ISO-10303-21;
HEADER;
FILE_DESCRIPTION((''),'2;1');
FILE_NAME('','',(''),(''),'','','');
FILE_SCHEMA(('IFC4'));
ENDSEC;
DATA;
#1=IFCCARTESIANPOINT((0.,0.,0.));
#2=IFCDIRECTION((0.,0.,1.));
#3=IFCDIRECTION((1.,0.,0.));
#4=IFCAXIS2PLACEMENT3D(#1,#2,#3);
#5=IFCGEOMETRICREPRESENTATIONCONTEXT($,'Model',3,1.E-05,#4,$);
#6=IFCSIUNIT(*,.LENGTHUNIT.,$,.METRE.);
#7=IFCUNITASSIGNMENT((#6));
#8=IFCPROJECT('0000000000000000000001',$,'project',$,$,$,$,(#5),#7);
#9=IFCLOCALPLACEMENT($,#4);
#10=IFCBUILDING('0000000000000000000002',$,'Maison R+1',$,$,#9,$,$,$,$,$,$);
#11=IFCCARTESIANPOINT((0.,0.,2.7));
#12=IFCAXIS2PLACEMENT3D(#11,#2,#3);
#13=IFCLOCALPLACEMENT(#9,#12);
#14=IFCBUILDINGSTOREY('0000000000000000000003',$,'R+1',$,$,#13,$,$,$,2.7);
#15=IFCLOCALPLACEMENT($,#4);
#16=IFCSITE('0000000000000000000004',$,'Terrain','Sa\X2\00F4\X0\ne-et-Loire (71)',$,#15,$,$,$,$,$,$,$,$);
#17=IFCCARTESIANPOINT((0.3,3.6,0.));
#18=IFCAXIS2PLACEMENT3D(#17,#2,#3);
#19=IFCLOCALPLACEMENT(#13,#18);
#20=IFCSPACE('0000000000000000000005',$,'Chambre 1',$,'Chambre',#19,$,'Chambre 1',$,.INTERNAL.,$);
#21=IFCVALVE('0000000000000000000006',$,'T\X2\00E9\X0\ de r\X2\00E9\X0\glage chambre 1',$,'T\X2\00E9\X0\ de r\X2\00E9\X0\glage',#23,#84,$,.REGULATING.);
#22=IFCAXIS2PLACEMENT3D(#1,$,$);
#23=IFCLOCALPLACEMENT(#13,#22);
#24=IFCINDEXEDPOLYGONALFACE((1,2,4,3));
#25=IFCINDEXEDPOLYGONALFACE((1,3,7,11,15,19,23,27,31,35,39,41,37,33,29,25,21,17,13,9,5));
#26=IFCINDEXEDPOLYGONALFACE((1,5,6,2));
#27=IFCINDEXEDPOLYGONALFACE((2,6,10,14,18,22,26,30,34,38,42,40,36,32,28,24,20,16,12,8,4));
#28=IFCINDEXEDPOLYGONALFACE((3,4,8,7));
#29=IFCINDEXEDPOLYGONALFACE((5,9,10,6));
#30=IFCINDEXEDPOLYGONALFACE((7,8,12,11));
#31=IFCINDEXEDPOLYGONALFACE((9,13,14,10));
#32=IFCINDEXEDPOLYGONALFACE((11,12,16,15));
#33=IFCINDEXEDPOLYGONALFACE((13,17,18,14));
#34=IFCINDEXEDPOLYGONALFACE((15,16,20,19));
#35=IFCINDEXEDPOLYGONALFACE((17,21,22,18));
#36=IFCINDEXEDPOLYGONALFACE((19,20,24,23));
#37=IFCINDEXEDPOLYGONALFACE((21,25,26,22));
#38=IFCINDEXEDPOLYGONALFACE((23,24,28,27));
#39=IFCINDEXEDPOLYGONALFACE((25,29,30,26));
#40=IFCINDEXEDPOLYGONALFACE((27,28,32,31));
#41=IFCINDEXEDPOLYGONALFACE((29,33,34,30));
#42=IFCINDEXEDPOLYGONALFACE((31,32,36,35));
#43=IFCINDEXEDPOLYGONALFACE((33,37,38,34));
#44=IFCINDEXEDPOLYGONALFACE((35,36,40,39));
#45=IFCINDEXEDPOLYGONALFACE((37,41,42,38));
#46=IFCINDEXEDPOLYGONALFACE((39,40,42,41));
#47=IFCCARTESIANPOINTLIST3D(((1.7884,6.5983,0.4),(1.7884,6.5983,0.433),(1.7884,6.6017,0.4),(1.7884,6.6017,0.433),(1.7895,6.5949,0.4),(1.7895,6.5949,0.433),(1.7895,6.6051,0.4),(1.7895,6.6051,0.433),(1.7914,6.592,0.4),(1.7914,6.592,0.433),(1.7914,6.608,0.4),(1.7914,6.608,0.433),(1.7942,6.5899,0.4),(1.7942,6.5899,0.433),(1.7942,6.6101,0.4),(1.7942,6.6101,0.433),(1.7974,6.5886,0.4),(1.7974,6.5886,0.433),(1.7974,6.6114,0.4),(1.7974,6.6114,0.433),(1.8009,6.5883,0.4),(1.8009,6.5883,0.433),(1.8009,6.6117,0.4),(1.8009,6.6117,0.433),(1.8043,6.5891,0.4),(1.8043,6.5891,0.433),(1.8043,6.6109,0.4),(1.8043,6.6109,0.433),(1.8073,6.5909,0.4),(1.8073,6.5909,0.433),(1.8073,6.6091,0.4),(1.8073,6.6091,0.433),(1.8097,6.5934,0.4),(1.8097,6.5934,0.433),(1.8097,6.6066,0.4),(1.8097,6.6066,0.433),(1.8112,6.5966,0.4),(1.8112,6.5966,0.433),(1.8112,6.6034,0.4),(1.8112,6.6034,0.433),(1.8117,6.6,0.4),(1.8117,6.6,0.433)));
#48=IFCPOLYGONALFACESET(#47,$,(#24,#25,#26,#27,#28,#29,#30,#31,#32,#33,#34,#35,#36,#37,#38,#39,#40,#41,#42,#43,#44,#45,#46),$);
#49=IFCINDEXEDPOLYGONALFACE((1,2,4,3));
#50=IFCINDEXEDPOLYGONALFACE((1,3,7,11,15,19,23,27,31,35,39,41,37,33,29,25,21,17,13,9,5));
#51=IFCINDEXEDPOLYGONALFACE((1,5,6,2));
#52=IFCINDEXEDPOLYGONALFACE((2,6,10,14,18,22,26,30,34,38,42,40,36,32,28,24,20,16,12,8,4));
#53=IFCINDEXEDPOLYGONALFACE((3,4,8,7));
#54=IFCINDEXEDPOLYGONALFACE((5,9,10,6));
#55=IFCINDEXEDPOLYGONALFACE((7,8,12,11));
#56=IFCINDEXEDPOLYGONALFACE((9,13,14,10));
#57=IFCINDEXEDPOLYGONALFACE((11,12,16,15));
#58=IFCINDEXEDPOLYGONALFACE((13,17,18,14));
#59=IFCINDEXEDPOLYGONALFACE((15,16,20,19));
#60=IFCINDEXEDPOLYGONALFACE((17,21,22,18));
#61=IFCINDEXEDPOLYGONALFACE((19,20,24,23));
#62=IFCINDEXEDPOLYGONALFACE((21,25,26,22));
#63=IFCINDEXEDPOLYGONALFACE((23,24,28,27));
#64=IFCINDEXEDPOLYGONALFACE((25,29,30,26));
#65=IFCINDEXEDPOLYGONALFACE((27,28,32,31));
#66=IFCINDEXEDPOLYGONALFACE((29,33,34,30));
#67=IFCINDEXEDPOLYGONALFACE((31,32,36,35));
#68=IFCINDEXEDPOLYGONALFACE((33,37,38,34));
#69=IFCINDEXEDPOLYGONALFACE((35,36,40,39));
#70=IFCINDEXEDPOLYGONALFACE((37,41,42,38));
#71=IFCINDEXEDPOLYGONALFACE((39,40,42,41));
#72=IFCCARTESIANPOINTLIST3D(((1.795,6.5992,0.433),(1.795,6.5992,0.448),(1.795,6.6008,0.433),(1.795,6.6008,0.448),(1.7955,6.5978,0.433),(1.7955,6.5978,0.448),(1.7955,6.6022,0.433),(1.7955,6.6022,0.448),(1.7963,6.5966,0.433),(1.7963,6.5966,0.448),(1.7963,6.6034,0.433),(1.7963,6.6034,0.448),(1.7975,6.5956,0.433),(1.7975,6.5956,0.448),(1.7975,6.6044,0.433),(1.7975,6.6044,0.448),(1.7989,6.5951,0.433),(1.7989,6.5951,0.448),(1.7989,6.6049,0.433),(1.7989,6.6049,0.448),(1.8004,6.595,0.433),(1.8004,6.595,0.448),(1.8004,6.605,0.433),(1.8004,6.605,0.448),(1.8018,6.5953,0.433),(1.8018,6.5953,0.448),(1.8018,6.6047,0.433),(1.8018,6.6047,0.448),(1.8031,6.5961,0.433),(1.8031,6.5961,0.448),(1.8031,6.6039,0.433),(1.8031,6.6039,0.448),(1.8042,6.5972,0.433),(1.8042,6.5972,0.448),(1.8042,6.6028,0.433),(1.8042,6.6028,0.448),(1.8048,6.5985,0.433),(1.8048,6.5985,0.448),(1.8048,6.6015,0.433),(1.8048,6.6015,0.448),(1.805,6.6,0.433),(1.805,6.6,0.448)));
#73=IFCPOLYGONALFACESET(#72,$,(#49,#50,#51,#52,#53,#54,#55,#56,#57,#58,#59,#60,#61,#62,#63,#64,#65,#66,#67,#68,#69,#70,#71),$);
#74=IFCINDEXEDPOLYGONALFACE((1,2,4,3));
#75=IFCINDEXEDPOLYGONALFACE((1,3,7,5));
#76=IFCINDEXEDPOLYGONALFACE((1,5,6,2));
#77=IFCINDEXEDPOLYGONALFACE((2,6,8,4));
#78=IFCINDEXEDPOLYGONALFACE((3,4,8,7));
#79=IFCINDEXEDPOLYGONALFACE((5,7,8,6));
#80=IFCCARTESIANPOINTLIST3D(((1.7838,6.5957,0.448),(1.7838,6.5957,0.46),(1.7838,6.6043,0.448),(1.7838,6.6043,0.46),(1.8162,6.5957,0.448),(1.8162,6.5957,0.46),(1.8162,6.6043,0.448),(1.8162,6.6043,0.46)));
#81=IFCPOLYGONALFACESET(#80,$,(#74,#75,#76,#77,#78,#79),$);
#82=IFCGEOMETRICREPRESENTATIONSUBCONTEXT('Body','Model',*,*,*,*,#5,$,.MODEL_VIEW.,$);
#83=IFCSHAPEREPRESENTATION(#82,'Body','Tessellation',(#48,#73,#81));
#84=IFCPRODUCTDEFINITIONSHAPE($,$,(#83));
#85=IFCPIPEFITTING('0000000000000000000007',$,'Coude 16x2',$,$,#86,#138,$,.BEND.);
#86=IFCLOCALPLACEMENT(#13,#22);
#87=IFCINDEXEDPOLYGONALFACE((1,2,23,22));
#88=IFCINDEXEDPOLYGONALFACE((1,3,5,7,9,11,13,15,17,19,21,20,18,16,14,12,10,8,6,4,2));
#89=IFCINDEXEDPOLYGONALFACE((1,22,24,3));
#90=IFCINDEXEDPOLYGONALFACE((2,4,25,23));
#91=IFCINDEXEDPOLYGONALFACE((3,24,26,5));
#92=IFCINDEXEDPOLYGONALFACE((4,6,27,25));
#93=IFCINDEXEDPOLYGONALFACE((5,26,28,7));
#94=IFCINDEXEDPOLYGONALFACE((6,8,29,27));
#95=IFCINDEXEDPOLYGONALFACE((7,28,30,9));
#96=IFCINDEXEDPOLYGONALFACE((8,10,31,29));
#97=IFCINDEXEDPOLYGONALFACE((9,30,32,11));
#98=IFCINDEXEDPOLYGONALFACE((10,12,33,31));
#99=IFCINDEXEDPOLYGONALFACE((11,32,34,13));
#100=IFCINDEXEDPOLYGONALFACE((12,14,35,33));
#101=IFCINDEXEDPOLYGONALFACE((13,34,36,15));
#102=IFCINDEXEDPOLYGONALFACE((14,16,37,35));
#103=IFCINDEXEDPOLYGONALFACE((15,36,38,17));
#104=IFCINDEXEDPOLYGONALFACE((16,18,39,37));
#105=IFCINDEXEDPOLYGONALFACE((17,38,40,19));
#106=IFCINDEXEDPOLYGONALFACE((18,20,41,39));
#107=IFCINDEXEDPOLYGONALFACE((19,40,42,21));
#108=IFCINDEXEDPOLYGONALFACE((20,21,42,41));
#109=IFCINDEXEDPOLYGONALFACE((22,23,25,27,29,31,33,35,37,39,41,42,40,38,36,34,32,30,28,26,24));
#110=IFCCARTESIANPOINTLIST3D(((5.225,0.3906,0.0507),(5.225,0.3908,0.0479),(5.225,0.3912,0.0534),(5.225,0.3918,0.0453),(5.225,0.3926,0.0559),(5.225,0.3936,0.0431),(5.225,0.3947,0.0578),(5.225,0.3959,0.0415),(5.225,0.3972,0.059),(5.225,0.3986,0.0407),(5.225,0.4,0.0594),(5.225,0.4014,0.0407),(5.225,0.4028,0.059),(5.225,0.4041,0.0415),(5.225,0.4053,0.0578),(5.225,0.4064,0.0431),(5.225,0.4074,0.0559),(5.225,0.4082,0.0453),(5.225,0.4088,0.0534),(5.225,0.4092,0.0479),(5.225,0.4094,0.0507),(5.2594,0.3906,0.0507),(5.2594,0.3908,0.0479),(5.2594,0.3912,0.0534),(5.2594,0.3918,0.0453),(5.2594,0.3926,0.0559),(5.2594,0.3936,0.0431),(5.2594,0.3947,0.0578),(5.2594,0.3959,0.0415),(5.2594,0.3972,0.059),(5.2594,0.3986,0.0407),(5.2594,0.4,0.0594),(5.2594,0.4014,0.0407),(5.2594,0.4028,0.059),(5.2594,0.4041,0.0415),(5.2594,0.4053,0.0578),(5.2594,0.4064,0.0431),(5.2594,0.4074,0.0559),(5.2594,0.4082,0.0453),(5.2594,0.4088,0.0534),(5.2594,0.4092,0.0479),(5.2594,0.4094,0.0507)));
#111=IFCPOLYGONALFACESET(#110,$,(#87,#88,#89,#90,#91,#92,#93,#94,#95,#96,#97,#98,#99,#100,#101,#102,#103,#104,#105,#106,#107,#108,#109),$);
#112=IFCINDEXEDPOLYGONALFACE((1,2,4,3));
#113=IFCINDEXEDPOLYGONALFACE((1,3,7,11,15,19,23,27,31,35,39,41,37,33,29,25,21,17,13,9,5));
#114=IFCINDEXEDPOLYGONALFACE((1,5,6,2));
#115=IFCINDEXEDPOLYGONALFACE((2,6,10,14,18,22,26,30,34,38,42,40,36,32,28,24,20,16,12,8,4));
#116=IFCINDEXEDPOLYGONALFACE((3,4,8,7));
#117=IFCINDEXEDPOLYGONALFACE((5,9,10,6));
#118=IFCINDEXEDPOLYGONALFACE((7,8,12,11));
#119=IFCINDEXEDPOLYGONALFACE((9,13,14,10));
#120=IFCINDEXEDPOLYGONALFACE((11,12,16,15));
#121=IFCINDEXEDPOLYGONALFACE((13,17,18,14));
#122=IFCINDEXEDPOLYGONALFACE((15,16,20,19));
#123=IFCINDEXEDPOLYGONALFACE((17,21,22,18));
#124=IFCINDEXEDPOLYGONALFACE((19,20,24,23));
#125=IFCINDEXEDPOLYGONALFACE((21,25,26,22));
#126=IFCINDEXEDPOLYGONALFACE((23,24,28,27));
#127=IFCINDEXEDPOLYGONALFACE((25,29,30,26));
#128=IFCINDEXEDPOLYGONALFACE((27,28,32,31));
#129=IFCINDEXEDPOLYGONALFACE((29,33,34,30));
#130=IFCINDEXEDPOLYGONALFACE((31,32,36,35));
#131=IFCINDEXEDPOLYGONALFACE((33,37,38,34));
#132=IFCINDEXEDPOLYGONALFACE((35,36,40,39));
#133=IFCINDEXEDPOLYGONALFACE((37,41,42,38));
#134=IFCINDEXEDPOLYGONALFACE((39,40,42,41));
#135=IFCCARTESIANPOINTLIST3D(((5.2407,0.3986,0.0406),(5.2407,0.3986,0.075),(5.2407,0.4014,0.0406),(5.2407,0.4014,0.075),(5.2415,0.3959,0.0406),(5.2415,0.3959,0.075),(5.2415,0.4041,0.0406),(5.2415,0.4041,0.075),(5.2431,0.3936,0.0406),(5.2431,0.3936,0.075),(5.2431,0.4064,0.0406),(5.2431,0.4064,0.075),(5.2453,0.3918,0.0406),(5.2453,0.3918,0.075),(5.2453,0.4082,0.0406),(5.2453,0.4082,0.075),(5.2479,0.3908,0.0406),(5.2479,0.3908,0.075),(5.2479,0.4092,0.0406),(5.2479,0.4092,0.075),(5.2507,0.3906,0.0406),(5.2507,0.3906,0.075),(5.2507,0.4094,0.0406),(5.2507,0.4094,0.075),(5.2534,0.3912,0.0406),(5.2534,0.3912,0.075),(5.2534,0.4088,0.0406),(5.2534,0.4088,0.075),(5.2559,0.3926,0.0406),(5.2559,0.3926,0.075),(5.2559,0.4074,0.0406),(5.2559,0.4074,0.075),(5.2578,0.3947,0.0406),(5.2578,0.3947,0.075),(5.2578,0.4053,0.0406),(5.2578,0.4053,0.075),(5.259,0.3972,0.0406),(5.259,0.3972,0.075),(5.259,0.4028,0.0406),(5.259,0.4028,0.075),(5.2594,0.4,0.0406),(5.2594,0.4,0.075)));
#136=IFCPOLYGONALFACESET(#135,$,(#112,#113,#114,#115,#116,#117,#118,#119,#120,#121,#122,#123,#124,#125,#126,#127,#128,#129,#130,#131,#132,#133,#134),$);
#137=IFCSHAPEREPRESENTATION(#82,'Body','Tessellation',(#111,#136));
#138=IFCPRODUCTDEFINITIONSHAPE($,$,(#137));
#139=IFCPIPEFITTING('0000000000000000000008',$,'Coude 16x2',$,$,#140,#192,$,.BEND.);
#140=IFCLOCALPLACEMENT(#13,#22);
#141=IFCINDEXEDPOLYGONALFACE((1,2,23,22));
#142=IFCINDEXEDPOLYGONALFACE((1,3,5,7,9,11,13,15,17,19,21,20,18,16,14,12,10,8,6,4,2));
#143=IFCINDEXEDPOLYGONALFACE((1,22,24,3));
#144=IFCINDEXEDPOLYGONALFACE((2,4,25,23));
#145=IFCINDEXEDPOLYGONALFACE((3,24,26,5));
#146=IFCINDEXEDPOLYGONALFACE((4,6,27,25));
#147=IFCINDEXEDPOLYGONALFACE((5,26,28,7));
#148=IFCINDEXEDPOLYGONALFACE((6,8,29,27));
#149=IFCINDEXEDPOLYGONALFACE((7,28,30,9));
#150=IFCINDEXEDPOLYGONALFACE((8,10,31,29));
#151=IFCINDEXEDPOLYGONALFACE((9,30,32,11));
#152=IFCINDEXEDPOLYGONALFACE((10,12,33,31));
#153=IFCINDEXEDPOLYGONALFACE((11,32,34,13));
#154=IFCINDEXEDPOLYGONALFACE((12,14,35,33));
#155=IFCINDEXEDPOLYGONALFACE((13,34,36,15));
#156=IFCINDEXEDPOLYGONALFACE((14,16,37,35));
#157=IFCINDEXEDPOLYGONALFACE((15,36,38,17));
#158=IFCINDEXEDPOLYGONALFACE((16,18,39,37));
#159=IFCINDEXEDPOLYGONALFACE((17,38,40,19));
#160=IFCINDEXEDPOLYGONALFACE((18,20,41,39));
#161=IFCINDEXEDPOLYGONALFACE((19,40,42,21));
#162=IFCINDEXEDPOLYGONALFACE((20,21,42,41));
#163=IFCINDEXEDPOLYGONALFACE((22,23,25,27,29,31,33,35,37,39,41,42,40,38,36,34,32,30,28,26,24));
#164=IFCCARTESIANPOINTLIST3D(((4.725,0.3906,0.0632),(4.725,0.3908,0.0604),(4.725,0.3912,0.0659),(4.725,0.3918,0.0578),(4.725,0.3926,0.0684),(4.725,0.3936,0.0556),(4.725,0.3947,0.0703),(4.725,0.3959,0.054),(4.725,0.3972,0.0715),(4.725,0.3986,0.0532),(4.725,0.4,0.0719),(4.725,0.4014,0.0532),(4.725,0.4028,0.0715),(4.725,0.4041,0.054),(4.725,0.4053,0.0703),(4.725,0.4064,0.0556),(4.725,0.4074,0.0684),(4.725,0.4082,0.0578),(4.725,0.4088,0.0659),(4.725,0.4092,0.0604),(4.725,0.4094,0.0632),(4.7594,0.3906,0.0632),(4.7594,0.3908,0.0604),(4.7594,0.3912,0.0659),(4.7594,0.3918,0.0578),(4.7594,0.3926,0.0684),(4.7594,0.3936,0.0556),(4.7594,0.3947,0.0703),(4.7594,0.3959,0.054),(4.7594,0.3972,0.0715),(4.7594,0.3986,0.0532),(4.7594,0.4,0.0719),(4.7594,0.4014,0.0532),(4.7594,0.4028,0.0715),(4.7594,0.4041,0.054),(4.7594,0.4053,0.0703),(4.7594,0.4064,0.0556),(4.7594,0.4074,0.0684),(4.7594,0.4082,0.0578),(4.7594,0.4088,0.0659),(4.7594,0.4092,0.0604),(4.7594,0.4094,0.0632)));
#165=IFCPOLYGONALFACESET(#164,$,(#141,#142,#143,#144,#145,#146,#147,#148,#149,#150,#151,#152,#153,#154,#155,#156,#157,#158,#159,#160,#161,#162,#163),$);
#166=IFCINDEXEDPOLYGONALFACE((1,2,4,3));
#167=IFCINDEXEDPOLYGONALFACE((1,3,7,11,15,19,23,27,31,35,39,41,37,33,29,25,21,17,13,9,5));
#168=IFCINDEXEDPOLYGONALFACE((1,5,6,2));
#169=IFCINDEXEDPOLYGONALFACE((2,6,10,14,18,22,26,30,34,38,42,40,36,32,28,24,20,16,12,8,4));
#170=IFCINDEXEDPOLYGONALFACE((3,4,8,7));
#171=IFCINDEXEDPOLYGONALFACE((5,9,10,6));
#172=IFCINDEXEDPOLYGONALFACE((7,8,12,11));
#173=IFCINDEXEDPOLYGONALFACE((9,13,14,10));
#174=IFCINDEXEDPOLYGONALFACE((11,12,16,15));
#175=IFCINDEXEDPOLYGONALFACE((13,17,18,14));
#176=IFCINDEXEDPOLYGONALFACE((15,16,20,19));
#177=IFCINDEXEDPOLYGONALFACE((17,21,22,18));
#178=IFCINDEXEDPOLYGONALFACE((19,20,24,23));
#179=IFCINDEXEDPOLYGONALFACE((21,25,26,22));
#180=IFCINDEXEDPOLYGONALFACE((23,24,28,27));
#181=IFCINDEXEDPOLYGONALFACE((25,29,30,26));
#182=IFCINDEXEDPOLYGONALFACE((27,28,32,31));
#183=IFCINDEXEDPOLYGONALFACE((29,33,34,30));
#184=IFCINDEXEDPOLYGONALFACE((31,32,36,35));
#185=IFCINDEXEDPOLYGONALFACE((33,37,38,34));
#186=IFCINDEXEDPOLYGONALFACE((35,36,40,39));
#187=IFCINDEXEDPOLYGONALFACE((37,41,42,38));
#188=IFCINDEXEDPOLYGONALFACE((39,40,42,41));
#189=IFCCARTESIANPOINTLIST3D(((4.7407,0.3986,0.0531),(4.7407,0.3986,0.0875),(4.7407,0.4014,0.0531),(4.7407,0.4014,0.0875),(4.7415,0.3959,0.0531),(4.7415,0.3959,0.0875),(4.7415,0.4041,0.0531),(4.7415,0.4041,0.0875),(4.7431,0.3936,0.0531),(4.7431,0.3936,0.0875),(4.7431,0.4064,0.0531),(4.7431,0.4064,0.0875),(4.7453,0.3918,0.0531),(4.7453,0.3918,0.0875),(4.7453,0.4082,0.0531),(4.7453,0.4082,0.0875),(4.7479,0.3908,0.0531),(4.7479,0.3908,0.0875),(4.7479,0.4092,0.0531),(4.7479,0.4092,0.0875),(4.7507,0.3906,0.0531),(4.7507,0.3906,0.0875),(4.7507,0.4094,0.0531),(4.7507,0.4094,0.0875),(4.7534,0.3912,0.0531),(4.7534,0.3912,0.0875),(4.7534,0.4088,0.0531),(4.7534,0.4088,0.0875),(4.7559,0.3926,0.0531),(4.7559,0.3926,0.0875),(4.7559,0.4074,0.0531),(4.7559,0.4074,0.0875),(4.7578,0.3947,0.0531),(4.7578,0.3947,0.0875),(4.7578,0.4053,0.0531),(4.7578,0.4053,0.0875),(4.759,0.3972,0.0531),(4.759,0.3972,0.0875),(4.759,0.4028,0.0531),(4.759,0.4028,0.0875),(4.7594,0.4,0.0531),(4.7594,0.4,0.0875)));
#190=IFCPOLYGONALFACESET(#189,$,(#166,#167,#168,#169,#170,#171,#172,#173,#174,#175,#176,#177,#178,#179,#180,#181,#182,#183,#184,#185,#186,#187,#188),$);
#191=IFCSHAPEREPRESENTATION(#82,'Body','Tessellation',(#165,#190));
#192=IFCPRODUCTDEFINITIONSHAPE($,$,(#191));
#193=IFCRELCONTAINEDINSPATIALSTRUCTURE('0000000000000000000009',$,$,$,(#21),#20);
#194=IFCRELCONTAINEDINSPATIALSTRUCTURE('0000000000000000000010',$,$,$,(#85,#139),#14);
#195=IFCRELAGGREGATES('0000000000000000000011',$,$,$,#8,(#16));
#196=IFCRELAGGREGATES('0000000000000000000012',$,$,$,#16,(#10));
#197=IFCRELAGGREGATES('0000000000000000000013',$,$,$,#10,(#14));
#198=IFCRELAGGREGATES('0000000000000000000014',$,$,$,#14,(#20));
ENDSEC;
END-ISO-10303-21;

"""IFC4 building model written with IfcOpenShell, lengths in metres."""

from ifc_helpers import new_model, si_unit, frame, frame_2d, origin_with_axes, place, context, subcontext, project, spatial, rectangle, circle, extrude, element, save


model = new_model("IFC4")

# Units and contexts
model_context = context("Model", 3, precision=1e-05, world=origin_with_axes())
body_context = subcontext(model_context, "Body", "Model", "MODEL_VIEW")
ifc_project = project(units=[si_unit("LENGTHUNIT", "METRE")], contexts=[model_context])

# Site, building, storey
site_placement = place(None, origin_with_axes())
site = spatial("IfcSite", under=ifc_project, at=site_placement, Name="Terrain", Description="Saône-et-Loire (71)")
building_placement = place(None, origin_with_axes())
building = spatial("IfcBuilding", under=site, at=building_placement, Name="Maison R+1")
storey_placement = place(building_placement, frame((0.0, 0.0, 2.7), z_axis=(0.0, 0.0, 1.0), x_axis=(1.0, 0.0, 0.0)))
storey = spatial("IfcBuildingStorey", under=building, at=storey_placement, Name="R+1", Elevation=2.7)

# Shared definitions
space_placement = place(storey_placement, frame((0.3, 3.6, 0.0), z_axis=(0.0, 0.0, 1.0), x_axis=(1.0, 0.0, 0.0)))
space = spatial("IfcSpace", under=storey, at=space_placement, Name="Chambre 1", ObjectType="Chambre", LongName="Chambre 1", PredefinedType="INTERNAL")

# Valve
valve_1_placement = place(space_placement, frame((1.5, 3.0, 0.4), z_axis=(0.0, 0.0, 1.0), x_axis=(1.0, 0.0, 0.0)))
element("IfcValve", 1, at=valve_1_placement, inside=space, Name="Té de réglage chambre 1", ObjectType="Té de réglage", PredefinedType="REGULATING", context=body_context, shape_type="SweptSolid", body=[
    extrude(circle(Radius=0.0117), origin_with_axes(), (0.0, 0.0, 1.0), 0.033),
    extrude(circle(Radius=0.005), frame((0.0, 0.0, 0.033), z_axis=(0.0, 0.0, 1.0), x_axis=(1.0, 0.0, 0.0)), (0.0, 0.0, 1.0), 0.015),
    extrude(rectangle(XDim=0.0324, YDim=0.0086, at=frame_2d((0.0162, 0.0043))), frame((-0.0162, -0.0043, 0.048), z_axis=(0.0, 0.0, 1.0), x_axis=(1.0, 0.0, 0.0)), (0.0, 0.0, 1.0), 0.012),
])

# Pipe fittings
for number, where, z_axis, x_axis, name in (
    (2, (5.25, 0.4, 0.05), (0.0, 0.0, 1.0), (1.0, 0.0, 0.0), "Coude 16x2"),
    (3, (4.75, 0.4, 0.0625), (0.0, 0.0, 1.0), (1.0, 0.0, 0.0), "Coude 16x2"),
):
    element("IfcPipeFitting", number, at=place(storey_placement, frame(where, z_axis=z_axis, x_axis=x_axis)), inside=storey, Name=name, PredefinedType="BEND", context=body_context, shape_type="SweptSolid", body=[
        extrude(circle(Radius=0.0094), frame((0.0094, 0.0, 0.0), z_axis=(-1.0, 0.0, 0.0), x_axis=(0.0, 0.0, 1.0)), (0.0, 0.0, 1.0), 0.0344),
        extrude(circle(Radius=0.0094), frame((0.0, 0.0, -0.0094), z_axis=(0.0, 0.0, 1.0), x_axis=(1.0, 0.0, 0.0)), (0.0, 0.0, 1.0), 0.0344),
    ])

save(model, "model.ifc")
